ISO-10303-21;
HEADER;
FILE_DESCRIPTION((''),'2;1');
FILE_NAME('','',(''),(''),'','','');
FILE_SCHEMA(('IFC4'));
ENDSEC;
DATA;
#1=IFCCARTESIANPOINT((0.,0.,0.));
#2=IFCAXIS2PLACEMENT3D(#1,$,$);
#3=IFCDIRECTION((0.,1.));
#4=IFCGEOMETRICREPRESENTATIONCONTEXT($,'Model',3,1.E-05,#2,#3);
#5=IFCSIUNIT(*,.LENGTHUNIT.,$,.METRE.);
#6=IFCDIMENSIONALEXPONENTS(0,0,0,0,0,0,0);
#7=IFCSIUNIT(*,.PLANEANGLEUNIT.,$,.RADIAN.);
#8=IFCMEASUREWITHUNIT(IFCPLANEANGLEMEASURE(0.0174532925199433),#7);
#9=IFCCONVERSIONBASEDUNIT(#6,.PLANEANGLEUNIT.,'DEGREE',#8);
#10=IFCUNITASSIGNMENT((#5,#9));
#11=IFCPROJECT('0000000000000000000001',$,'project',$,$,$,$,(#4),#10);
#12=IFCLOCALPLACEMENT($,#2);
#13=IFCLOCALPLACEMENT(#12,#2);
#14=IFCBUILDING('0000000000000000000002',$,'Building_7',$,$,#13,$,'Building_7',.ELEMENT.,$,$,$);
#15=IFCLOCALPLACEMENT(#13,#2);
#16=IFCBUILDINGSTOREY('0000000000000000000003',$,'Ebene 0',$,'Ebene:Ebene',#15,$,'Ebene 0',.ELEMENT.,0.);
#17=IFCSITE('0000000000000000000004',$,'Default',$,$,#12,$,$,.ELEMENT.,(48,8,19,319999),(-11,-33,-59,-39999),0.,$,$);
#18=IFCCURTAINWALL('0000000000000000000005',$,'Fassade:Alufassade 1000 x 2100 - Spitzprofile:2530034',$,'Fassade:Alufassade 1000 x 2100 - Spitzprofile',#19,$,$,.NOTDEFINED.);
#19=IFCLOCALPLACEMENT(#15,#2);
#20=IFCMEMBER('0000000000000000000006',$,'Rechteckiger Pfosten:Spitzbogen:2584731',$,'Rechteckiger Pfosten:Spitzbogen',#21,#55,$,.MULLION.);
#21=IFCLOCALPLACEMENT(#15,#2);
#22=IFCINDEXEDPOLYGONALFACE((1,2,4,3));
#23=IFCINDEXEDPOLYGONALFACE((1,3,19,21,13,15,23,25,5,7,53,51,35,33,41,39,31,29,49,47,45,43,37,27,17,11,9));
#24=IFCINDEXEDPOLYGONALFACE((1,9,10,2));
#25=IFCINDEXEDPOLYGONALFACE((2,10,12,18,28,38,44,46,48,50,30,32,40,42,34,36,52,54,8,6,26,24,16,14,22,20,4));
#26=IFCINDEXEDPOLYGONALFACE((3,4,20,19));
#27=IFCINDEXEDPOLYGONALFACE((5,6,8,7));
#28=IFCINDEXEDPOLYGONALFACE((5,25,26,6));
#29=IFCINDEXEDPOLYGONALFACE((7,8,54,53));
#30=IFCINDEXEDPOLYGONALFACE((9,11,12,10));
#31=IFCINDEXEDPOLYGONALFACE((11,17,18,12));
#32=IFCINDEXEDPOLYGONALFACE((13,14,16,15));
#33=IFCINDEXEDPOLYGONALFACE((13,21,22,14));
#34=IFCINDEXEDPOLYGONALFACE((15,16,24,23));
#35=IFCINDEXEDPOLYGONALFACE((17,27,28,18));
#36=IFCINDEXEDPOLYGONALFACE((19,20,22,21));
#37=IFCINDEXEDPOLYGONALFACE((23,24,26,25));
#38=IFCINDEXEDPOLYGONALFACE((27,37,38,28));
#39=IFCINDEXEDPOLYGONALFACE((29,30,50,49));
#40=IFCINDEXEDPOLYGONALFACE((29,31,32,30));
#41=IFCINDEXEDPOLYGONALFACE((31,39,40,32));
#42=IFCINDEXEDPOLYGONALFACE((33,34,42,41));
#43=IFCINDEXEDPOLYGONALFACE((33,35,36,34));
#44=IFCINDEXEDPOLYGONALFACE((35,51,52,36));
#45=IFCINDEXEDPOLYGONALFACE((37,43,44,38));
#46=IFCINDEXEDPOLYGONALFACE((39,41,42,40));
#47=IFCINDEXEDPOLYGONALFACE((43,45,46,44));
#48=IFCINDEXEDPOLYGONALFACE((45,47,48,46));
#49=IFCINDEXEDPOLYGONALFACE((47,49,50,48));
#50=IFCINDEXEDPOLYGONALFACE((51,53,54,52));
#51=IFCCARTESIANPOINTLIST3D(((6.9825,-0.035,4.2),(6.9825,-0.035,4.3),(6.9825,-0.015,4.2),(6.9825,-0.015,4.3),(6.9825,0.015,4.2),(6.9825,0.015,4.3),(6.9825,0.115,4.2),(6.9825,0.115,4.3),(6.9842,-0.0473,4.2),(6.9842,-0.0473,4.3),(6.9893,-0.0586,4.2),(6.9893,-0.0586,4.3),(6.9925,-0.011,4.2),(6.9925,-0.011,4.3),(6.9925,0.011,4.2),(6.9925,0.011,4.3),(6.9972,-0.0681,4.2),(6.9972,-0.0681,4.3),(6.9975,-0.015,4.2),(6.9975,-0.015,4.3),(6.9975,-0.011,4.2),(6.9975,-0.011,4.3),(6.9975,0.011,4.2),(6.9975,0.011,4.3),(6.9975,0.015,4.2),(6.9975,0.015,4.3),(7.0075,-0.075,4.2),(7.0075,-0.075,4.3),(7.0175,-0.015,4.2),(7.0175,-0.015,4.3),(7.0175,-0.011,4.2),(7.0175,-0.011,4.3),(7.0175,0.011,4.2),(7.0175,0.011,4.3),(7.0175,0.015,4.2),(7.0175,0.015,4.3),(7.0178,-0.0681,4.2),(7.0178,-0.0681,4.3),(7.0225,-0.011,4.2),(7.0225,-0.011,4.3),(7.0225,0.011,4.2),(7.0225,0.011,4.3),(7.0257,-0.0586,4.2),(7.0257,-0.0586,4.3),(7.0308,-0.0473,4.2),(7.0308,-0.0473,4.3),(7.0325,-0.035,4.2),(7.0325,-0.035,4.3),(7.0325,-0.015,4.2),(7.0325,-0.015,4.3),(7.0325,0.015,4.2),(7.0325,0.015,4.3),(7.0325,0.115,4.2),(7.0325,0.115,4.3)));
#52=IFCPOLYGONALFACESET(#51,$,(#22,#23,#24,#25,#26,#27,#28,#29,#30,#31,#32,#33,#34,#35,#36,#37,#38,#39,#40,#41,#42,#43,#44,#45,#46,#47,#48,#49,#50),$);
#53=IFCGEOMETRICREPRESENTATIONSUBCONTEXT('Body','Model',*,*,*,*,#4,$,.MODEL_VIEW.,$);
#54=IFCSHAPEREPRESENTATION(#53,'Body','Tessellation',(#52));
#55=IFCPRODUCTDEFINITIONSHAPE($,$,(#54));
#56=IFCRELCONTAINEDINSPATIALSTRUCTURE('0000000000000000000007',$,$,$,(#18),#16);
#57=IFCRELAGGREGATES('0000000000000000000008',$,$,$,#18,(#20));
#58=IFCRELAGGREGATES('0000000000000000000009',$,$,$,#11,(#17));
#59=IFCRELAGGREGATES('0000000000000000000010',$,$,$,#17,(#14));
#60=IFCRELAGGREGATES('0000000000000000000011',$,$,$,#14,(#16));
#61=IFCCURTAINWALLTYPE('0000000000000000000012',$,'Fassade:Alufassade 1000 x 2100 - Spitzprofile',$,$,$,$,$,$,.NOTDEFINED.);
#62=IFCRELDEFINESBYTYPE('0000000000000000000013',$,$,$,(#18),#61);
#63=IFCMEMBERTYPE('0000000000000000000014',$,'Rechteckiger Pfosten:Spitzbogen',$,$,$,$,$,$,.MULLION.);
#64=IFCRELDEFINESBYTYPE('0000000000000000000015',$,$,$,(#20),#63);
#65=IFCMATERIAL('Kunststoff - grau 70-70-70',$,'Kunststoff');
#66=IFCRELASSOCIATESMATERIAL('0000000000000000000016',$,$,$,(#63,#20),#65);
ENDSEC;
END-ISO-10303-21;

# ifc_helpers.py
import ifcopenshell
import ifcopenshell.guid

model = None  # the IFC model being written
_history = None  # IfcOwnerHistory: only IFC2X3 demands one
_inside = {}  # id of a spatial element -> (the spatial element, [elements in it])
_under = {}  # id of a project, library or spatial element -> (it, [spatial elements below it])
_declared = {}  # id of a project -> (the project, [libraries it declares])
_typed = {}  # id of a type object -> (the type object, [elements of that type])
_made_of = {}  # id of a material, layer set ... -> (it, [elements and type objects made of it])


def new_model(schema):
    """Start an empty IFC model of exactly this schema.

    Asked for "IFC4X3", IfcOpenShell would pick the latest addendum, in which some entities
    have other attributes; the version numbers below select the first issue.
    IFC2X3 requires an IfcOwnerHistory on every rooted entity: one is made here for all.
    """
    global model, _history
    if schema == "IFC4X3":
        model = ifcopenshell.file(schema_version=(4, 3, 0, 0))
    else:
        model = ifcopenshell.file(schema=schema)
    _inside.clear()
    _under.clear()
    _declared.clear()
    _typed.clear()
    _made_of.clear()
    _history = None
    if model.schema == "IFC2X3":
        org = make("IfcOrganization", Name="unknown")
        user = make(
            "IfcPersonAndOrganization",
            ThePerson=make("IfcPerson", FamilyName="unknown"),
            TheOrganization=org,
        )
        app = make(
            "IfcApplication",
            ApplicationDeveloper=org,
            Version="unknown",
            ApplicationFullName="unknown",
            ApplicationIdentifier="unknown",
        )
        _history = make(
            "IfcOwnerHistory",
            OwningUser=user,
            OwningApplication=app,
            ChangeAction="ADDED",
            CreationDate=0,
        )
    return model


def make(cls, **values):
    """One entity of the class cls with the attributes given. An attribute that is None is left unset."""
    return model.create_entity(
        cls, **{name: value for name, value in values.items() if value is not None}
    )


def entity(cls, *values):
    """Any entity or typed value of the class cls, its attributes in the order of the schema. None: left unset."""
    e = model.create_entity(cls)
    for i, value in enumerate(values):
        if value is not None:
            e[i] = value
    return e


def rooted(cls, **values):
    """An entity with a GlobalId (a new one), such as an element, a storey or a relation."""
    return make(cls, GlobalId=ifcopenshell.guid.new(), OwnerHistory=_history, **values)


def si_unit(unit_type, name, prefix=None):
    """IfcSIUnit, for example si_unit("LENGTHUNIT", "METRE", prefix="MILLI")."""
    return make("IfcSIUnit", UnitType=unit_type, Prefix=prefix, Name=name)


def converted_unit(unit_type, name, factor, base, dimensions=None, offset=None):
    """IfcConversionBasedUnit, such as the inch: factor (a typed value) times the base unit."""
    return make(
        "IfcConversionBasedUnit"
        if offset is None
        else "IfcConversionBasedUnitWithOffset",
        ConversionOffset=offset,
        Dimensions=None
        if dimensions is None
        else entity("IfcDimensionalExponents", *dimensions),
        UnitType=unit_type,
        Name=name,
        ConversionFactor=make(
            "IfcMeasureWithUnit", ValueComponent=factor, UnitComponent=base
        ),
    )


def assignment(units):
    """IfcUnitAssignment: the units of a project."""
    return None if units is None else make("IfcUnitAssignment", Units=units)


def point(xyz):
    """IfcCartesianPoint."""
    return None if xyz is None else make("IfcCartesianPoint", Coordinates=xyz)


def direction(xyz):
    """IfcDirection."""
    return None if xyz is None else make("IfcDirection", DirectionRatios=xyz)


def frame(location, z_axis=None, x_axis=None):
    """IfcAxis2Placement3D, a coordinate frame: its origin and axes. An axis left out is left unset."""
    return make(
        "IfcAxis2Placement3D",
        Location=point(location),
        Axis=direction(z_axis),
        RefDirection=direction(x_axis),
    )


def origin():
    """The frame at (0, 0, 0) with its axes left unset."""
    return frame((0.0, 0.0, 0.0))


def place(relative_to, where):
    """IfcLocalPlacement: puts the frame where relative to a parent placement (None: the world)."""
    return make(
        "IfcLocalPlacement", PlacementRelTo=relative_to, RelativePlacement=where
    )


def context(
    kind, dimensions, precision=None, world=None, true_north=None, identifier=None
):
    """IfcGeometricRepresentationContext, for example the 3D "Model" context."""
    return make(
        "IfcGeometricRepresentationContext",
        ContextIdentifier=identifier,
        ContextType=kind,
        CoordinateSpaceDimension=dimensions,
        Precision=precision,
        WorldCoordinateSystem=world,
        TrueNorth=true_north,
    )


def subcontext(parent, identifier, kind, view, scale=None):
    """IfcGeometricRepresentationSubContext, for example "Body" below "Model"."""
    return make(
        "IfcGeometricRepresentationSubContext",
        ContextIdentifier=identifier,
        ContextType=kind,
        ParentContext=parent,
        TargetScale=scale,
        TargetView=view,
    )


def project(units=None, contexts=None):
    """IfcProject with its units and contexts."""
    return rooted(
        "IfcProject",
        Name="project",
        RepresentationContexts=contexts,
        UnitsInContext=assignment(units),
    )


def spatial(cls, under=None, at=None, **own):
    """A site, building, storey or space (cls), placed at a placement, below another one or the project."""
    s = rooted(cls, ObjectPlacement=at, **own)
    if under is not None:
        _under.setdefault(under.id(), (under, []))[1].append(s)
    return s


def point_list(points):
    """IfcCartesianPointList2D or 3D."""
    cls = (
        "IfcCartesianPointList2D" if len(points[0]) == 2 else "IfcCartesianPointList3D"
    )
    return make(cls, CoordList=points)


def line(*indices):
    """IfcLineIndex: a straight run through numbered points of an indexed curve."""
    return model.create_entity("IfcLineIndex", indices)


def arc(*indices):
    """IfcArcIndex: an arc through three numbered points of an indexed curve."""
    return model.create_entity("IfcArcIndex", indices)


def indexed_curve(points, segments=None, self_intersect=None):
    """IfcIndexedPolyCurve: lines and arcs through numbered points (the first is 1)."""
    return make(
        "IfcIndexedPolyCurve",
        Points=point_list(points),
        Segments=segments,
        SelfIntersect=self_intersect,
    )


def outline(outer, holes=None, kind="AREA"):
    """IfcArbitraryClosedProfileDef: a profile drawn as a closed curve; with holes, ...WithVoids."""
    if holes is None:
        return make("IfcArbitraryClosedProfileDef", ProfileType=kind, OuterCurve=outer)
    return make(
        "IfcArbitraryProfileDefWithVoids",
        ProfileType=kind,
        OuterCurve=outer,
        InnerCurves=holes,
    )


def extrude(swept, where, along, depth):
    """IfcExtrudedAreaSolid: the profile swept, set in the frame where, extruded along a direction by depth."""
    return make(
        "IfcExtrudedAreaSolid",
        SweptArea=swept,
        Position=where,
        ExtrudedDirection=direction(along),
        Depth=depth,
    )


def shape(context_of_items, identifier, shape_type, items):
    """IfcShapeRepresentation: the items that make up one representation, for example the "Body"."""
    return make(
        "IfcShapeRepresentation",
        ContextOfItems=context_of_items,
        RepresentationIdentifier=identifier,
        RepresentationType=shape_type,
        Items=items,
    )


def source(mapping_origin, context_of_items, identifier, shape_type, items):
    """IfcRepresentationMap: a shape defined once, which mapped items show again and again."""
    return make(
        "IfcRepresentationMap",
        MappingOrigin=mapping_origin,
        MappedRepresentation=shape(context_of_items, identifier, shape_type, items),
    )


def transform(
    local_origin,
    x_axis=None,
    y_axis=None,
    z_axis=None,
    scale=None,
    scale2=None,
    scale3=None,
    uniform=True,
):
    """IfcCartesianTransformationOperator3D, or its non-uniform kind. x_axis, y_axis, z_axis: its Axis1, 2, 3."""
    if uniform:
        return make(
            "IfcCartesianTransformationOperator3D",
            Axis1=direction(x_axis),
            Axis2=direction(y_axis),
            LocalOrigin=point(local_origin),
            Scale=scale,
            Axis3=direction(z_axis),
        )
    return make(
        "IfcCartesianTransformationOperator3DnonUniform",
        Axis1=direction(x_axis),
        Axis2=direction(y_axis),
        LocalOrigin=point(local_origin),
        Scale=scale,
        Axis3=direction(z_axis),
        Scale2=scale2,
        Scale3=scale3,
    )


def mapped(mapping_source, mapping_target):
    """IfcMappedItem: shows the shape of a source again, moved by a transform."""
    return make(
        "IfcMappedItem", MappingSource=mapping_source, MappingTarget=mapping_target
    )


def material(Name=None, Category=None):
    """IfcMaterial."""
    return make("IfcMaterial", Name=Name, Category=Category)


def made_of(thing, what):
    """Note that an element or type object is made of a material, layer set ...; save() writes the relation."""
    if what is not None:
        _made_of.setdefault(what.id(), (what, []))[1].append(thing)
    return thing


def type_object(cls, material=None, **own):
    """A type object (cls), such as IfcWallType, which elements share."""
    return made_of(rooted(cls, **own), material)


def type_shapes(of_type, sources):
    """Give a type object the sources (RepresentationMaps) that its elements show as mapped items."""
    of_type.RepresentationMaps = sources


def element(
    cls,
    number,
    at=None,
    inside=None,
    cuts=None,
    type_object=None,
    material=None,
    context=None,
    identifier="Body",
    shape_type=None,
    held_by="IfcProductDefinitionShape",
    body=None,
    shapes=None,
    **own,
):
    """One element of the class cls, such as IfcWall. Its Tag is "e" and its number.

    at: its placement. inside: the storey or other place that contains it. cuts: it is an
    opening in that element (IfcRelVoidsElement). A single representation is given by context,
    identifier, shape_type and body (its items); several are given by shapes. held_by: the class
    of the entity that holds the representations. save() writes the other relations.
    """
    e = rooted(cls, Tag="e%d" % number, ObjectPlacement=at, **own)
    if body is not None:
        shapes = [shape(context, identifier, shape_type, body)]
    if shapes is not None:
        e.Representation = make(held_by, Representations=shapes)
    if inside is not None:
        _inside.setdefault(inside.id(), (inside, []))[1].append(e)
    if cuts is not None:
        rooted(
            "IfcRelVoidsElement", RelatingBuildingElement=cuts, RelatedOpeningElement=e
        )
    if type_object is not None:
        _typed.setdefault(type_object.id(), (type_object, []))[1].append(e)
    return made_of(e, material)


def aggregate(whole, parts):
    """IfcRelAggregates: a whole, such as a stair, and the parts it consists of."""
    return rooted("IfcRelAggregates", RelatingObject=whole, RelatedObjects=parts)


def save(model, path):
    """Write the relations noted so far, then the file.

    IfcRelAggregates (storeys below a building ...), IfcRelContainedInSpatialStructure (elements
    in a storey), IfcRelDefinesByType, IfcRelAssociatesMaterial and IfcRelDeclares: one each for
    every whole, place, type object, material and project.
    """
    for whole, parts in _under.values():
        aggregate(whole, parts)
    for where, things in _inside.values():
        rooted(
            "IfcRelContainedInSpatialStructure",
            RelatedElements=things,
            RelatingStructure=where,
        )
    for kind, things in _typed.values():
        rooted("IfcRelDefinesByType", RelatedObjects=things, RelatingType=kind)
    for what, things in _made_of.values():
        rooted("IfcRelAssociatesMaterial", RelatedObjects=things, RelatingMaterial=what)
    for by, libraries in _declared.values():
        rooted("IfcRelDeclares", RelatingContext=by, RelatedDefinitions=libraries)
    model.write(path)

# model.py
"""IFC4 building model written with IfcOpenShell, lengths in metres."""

from ifc_helpers import new_model, entity, si_unit, converted_unit, direction, frame, origin, place, context, subcontext, project, spatial, line, arc, indexed_curve, outline, extrude, source, transform, mapped, material, type_object, type_shapes, element, aggregate, save


model = new_model("IFC4")

# Units and contexts
model_context = context("Model", 3, precision=1e-05, world=origin(), true_north=direction((0.0, 1.0)))
body_context = subcontext(model_context, "Body", "Model", "MODEL_VIEW")
ifc_project = project(units=[si_unit("LENGTHUNIT", "METRE"), converted_unit("PLANEANGLEUNIT", "DEGREE", entity("IfcPlaneAngleMeasure", 0.0174532925199433), si_unit("PLANEANGLEUNIT", "RADIAN"), dimensions=[0, 0, 0, 0, 0, 0, 0])], contexts=[model_context])

# Site, building, storey
site_placement = place(None, origin())
site = spatial("IfcSite", under=ifc_project, at=site_placement, Name="Default", CompositionType="ELEMENT", RefLatitude=(48, 8, 19, 319999), RefLongitude=(-11, -33, -59, -39999), RefElevation=0.0)
building_placement = place(site_placement, origin())
building = spatial("IfcBuilding", under=site, at=building_placement, Name="Building_7", LongName="Building_7", CompositionType="ELEMENT")
storey_placement = place(building_placement, origin())
storey = spatial("IfcBuildingStorey", under=building, at=storey_placement, Name="Ebene 0", ObjectType="Ebene:Ebene", LongName="Ebene 0", CompositionType="ELEMENT", Elevation=0.0)

# Curtain wall, member
curtain_wall_type = type_object("IfcCurtainWallType", Name="Fassade:Alufassade 1000 x 2100 - Spitzprofile", PredefinedType="NOTDEFINED")
curtain_wall_placement = place(storey_placement, origin())
curtain_wall = element("IfcCurtainWall", 1, at=curtain_wall_placement, inside=storey, type_object=curtain_wall_type, Name="Fassade:Alufassade 1000 x 2100 - Spitzprofile:2530034", ObjectType="Fassade:Alufassade 1000 x 2100 - Spitzprofile", PredefinedType="NOTDEFINED")
ifc_material = material(Name="Kunststoff - grau 70-70-70", Category="Kunststoff")
member_type_1 = type_object("IfcMemberType", Name="Rechteckiger Pfosten:Spitzbogen", PredefinedType="MULLION", material=ifc_material)
shared_shape_1 = source(origin(), body_context, "Body", "SweptSolid", [
    extrude(outline(indexed_curve([(-0.111, -0.025), (-0.011, -0.025), (-0.011, -0.01), (-0.007, -0.01), (-0.007, -0.015), (0.015, -0.015), (0.015, -0.01), (0.019, -0.01), (0.019, -0.025), (0.039, -0.025), (0.0626, -0.0182), (0.079, 0.0), (0.0626, 0.0182), (0.039, 0.025), (0.019, 0.025), (0.019, 0.01), (0.015, 0.01), (0.015, 0.015), (-0.007, 0.015), (-0.007, 0.01), (-0.011, 0.01), (-0.011, 0.025), (-0.111, 0.025)], segments=[line(1, 2, 3, 4, 5, 6, 7, 8, 9, 10), arc(10, 11, 12), arc(12, 13, 14), line(14, 15, 16, 17, 18, 19, 20, 21, 22, 23, 1)], self_intersect=False)), frame((0.0, 0.004, -0.1), z_axis=(0.0, 0.0, 1.0), x_axis=(0.0, -1.0, 0.0)), (0.0, 0.0, 1.0), 0.1),
])
type_shapes(member_type_1, [shared_shape_1])
member_1_placement = place(curtain_wall_placement, frame((7.0075, 0.0, 4.2), z_axis=(0.0, 0.0, -1.0), x_axis=(-1.0, 0.0, 0.0)))
member_1 = element("IfcMember", 2, at=member_1_placement, type_object=member_type_1, material=ifc_material, Name="Rechteckiger Pfosten:Spitzbogen:2584731", ObjectType="Rechteckiger Pfosten:Spitzbogen", PredefinedType="MULLION", context=body_context, shape_type="MappedRepresentation", body=[
    mapped(shared_shape_1, transform((0.0, 0.0, 0.0), scale=1.0)),
])
aggregate(curtain_wall, [member_1])

save(model, "model.ifc")
